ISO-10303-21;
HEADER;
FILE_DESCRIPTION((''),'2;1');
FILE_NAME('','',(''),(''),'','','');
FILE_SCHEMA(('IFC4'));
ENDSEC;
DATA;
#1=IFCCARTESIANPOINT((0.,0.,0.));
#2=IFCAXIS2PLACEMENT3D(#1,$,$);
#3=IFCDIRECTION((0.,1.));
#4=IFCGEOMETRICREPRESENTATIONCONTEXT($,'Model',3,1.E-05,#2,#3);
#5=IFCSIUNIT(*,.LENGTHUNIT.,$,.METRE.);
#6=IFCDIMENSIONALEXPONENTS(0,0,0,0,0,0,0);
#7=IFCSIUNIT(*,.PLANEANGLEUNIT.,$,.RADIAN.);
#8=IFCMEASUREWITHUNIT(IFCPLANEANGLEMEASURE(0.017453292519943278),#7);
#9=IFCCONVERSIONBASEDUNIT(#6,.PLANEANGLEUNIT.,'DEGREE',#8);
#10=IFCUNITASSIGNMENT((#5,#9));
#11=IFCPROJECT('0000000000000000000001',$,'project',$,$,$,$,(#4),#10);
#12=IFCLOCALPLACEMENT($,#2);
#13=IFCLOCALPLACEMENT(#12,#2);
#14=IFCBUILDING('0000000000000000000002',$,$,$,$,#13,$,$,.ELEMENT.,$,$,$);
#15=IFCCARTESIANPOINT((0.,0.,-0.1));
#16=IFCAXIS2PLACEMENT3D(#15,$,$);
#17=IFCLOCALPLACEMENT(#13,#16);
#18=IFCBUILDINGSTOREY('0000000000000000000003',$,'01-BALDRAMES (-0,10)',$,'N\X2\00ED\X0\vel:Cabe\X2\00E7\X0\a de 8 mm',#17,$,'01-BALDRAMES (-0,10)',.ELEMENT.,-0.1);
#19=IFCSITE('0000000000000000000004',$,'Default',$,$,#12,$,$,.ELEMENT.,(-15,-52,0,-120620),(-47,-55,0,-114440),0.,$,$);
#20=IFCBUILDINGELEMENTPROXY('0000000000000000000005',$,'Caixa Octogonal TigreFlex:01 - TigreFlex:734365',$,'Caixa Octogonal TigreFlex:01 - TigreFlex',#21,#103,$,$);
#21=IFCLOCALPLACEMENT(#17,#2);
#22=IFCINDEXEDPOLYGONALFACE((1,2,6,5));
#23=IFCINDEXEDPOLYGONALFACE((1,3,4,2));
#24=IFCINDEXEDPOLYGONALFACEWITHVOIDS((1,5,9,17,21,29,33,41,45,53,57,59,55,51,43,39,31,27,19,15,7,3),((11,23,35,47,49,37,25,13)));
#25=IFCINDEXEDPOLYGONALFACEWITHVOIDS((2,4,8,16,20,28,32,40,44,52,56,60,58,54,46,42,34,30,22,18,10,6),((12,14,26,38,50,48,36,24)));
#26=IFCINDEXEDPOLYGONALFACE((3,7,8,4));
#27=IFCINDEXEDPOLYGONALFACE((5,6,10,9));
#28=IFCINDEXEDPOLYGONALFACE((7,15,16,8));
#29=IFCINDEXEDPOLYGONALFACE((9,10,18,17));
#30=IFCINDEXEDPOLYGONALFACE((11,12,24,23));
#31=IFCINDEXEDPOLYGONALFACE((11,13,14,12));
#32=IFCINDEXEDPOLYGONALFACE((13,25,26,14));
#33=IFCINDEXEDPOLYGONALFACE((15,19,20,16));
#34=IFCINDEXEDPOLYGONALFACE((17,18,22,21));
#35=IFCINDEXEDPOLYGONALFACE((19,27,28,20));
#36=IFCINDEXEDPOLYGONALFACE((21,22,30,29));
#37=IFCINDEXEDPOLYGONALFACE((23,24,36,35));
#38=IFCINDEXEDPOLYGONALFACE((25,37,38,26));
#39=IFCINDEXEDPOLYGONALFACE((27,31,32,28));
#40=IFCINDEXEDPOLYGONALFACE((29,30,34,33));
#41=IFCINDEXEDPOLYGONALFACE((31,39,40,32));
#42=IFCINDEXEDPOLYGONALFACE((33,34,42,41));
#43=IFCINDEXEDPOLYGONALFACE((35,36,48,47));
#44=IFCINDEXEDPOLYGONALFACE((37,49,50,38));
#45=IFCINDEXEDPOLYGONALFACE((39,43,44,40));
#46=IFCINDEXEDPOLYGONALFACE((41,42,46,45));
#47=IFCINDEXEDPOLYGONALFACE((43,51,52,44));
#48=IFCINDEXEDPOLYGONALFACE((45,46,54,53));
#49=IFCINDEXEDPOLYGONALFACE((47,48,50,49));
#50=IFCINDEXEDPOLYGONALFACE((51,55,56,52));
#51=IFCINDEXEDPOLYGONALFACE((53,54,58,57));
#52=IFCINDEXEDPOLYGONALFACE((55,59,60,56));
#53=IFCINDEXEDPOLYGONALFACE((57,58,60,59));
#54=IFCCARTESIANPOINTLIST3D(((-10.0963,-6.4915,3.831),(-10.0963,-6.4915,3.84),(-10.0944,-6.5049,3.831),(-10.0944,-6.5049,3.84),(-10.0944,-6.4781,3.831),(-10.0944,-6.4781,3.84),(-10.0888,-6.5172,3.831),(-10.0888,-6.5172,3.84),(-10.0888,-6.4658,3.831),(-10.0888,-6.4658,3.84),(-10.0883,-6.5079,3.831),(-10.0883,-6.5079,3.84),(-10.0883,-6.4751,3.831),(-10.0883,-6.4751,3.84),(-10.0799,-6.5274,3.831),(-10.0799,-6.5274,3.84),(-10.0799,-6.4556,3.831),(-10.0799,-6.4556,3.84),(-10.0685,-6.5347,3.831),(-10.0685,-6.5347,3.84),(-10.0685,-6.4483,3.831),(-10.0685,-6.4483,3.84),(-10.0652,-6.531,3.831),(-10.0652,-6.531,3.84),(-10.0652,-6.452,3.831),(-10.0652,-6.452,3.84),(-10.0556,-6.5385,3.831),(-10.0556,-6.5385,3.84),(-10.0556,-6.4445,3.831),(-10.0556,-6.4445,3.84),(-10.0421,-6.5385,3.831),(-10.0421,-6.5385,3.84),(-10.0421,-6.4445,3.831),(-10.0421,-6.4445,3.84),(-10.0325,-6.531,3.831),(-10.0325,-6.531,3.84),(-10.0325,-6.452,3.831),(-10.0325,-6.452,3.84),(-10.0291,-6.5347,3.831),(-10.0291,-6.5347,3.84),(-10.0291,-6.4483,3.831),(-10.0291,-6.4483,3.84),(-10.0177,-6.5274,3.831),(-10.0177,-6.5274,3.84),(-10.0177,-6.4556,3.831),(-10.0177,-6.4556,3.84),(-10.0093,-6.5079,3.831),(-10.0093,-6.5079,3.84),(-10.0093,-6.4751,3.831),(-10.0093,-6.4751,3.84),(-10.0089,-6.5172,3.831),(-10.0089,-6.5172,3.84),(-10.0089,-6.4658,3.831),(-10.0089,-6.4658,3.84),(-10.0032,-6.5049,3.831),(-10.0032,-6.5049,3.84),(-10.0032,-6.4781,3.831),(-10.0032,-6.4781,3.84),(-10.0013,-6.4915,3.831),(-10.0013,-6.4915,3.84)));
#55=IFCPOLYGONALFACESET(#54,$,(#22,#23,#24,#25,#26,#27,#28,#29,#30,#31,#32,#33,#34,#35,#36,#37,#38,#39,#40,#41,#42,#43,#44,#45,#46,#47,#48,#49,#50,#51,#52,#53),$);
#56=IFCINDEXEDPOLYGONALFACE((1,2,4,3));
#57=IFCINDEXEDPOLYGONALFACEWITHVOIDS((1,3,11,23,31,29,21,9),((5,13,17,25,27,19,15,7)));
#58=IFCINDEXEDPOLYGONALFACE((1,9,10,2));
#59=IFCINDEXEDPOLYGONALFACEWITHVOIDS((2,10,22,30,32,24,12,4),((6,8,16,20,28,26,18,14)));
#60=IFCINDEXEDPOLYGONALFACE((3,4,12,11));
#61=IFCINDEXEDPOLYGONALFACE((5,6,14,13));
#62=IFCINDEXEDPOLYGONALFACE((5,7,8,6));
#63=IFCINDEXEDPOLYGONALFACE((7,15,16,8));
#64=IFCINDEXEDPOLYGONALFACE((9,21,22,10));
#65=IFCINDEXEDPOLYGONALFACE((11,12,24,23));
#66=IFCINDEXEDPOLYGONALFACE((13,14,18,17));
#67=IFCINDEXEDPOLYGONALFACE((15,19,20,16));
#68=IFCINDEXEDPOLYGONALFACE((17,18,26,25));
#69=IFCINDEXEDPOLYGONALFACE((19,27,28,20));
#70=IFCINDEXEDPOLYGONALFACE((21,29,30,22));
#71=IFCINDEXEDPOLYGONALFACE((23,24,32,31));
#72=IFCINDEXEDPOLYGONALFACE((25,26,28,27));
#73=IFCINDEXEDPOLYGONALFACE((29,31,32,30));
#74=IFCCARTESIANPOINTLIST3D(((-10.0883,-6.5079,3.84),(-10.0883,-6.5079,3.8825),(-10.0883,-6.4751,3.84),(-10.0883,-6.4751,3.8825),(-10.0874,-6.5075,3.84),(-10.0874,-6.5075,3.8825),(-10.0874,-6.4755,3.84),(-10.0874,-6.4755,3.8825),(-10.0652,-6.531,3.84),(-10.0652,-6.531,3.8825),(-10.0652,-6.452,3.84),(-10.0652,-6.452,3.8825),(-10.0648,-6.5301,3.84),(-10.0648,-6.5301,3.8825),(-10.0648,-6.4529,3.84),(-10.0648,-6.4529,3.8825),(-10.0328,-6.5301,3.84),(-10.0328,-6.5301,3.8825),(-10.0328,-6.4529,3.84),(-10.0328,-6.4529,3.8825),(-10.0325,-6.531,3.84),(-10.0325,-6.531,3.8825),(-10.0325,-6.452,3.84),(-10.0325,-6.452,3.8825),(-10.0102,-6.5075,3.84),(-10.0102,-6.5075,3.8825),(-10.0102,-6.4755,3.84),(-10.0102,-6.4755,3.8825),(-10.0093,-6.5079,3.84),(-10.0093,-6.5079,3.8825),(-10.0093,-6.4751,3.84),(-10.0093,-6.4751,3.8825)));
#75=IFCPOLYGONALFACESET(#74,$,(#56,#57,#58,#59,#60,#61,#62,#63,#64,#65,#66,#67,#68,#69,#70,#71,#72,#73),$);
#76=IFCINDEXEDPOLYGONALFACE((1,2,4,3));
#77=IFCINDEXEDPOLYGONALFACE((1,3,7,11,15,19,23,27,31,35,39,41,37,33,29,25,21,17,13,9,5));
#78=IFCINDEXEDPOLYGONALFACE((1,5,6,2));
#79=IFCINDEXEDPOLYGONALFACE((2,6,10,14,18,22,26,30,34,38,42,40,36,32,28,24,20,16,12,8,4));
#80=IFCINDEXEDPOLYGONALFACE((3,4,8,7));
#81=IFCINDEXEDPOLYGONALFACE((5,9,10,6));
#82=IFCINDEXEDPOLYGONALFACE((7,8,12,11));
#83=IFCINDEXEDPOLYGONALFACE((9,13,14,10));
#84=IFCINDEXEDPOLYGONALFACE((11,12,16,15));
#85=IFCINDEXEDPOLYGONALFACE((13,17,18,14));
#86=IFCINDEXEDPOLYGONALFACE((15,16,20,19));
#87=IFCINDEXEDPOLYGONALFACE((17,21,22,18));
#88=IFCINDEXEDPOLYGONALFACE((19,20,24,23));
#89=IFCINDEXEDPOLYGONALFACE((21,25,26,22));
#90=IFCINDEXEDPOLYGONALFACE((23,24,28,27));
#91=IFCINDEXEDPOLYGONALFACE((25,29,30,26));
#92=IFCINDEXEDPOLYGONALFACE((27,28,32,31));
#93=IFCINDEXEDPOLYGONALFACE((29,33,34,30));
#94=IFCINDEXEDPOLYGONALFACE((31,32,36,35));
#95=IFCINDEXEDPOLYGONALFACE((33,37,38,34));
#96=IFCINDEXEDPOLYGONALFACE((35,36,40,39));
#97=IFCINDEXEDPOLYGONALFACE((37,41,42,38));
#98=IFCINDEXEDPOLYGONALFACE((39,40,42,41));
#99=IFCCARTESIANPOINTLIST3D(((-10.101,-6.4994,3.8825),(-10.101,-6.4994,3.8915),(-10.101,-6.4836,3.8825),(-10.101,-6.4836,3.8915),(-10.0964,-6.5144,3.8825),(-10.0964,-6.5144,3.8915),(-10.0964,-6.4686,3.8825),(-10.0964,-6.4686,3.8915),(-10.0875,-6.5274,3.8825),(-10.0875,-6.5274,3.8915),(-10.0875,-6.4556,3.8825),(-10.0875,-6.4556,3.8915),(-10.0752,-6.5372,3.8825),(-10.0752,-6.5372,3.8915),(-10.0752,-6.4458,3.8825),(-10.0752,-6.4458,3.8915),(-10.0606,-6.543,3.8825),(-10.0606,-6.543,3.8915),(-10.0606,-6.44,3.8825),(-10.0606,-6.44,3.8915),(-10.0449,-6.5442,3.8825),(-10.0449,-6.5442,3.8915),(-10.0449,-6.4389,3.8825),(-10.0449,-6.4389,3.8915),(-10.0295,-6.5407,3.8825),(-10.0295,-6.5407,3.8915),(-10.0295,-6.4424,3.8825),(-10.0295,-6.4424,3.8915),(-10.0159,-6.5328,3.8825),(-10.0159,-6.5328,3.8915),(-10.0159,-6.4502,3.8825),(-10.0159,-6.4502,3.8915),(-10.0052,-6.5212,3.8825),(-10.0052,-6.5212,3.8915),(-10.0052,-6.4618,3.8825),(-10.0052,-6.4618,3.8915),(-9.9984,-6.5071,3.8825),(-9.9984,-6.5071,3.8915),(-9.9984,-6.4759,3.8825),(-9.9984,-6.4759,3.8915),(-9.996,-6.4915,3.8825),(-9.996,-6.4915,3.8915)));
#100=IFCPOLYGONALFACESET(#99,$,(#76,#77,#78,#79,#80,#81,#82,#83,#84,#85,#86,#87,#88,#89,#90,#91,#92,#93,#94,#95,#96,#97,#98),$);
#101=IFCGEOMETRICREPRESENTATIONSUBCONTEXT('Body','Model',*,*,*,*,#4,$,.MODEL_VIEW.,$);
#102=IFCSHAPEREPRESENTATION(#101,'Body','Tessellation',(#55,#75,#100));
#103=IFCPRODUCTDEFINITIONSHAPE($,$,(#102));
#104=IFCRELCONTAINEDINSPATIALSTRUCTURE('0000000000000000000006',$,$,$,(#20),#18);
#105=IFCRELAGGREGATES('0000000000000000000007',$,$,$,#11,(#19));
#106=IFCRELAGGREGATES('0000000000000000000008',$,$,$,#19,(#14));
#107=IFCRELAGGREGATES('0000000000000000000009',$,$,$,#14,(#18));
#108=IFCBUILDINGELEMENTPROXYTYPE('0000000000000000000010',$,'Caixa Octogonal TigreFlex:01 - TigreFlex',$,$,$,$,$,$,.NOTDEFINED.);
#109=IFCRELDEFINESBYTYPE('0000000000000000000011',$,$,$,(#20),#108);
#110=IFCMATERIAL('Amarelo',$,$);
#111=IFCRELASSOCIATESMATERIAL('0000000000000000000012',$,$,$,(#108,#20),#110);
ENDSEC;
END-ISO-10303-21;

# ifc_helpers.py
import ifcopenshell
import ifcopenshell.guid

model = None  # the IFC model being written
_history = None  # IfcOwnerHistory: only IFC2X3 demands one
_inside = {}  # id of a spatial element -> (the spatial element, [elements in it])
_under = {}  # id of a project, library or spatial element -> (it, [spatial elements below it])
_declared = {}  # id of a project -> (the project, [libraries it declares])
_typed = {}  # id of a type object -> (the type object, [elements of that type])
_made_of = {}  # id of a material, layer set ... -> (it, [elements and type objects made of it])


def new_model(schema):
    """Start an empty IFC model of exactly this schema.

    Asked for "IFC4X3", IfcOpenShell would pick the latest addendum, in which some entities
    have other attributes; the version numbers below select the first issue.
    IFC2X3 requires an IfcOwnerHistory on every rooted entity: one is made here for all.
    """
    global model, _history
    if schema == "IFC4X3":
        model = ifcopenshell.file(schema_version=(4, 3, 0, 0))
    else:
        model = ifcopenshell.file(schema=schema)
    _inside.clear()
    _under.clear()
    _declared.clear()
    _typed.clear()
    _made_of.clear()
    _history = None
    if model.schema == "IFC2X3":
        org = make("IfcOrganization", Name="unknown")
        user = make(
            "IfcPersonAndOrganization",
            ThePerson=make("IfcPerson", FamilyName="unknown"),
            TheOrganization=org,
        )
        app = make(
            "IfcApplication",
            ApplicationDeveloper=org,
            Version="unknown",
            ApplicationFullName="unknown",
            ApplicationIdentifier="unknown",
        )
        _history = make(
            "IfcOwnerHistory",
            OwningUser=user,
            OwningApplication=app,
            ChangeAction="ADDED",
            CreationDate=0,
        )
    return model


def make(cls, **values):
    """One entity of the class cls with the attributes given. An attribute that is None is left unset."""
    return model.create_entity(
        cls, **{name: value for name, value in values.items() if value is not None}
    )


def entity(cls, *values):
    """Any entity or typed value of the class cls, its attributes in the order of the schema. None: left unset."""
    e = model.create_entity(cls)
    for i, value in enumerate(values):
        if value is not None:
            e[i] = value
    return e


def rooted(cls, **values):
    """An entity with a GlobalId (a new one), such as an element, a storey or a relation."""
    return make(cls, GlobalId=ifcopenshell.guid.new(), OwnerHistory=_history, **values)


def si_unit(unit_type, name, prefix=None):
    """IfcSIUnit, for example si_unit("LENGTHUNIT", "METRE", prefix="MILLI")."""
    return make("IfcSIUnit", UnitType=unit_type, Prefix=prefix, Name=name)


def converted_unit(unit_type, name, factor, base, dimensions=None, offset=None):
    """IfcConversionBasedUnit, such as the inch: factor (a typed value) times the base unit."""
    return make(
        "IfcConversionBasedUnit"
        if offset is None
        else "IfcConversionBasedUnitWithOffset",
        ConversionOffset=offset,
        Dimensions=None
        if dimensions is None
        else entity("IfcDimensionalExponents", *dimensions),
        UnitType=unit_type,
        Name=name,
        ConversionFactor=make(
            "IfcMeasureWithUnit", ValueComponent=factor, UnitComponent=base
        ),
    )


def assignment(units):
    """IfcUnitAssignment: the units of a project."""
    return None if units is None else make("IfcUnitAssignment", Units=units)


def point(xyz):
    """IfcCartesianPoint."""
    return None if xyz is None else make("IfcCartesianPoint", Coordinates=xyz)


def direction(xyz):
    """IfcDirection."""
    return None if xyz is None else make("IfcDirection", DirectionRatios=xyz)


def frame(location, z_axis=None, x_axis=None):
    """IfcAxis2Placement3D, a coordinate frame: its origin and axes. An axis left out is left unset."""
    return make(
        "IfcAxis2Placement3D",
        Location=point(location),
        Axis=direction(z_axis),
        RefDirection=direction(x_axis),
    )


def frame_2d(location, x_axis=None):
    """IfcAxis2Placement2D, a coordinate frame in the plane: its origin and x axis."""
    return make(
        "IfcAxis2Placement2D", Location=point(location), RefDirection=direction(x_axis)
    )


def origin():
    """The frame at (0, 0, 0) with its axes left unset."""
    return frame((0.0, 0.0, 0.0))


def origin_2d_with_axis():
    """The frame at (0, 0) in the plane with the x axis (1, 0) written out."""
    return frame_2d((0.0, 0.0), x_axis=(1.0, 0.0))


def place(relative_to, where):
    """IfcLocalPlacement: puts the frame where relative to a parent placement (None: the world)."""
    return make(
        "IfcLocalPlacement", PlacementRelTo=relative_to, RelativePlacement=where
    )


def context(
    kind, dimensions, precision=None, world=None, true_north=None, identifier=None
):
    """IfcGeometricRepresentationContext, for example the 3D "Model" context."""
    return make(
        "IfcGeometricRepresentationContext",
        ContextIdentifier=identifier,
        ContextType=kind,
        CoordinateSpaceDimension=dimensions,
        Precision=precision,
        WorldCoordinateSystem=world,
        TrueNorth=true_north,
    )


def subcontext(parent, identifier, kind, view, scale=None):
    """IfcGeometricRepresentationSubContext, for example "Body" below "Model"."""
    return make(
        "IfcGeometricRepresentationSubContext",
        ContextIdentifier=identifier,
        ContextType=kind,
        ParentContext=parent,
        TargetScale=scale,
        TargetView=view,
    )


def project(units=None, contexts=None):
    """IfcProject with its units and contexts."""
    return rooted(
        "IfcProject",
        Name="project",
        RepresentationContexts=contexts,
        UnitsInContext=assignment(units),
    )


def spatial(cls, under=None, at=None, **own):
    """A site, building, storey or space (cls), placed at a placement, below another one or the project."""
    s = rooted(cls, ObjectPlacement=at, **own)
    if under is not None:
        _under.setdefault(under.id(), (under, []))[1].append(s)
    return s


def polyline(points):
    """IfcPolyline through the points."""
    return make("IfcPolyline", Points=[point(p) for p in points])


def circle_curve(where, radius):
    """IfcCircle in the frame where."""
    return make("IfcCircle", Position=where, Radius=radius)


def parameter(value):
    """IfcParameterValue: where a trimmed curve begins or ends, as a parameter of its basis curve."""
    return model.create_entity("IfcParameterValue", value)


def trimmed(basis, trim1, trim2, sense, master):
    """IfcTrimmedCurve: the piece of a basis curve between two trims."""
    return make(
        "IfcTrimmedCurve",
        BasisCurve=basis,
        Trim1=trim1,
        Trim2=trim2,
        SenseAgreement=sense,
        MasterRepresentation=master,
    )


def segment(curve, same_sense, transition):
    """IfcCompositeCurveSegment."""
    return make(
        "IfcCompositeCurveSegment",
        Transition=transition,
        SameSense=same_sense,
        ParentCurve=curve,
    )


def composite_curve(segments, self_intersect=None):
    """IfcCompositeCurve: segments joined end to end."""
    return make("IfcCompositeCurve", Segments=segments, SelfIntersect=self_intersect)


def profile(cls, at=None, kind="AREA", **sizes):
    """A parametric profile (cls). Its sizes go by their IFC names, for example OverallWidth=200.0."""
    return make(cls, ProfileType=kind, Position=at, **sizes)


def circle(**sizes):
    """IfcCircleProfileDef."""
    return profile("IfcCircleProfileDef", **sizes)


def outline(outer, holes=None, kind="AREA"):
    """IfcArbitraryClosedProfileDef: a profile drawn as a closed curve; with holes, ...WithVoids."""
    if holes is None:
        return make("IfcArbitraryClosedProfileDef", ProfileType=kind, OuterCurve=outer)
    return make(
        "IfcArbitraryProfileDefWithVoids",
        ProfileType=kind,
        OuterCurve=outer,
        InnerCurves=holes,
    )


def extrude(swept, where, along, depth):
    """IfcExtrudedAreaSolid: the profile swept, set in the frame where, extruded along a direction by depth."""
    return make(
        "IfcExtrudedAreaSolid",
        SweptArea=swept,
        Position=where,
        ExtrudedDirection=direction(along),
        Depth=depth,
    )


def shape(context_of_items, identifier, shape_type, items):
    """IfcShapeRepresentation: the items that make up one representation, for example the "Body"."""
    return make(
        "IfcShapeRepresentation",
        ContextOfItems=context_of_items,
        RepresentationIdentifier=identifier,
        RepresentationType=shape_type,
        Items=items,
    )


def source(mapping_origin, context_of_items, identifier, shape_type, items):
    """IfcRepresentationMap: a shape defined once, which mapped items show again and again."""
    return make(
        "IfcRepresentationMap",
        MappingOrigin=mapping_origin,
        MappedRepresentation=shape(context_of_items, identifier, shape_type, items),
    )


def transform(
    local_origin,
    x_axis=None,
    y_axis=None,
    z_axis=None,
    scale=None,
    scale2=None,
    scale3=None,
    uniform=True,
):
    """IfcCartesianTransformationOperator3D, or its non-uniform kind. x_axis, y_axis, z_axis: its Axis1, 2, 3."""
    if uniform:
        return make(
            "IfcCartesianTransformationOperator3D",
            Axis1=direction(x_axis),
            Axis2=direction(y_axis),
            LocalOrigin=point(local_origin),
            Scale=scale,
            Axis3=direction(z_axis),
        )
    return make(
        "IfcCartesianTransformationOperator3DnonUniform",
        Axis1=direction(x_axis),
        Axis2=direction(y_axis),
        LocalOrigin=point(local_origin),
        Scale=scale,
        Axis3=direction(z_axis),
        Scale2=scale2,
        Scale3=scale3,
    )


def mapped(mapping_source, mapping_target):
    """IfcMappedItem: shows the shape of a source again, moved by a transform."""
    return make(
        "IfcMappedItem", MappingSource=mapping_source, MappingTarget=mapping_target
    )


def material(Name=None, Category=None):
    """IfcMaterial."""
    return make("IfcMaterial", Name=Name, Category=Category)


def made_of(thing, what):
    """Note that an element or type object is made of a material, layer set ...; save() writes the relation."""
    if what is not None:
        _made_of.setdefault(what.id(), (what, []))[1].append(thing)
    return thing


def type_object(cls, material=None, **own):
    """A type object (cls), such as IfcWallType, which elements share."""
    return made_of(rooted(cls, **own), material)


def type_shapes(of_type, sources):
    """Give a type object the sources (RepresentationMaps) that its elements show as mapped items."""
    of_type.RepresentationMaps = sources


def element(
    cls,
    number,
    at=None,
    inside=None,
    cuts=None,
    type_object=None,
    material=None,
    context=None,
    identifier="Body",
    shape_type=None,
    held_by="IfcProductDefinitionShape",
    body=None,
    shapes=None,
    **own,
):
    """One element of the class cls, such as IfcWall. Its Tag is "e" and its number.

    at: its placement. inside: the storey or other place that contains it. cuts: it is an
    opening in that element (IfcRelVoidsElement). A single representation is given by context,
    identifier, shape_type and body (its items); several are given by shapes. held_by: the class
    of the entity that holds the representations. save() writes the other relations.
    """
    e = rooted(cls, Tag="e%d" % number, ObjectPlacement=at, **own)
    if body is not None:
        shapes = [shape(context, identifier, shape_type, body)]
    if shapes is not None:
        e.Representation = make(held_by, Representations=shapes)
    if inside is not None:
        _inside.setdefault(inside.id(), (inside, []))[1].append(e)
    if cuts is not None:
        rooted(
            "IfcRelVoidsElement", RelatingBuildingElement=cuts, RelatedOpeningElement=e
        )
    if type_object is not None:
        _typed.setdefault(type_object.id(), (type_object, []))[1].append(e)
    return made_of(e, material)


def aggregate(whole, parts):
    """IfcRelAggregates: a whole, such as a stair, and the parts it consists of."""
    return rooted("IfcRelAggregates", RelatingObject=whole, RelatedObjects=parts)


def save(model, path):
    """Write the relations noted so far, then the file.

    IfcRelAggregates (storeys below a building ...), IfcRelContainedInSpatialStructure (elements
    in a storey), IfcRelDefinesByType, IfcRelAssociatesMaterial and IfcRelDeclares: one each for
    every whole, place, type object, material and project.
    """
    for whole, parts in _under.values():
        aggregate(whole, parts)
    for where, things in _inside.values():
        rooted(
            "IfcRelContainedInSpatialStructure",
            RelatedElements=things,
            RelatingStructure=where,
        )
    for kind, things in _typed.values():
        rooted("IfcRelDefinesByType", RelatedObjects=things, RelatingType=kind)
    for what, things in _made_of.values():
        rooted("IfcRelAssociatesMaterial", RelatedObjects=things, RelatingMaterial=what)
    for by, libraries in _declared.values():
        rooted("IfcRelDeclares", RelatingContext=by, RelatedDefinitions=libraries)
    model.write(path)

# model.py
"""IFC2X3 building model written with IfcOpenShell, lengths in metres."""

from ifc_helpers import new_model, entity, si_unit, converted_unit, direction, frame, frame_2d, origin, origin_2d_with_axis, place, context, subcontext, project, spatial, polyline, circle_curve, parameter, trimmed, segment, composite_curve, circle, outline, extrude, source, transform, mapped, material, type_object, type_shapes, element, save


model = new_model("IFC2X3")

# Units and contexts
model_context = context("Model", 3, precision=1e-05, world=origin(), true_north=direction((0.0, 1.0)))
body_context = subcontext(model_context, "Body", "Model", "MODEL_VIEW")
ifc_project = project(units=[si_unit("LENGTHUNIT", "METRE"), converted_unit("PLANEANGLEUNIT", "DEGREE", entity("IfcPlaneAngleMeasure", 0.017453292519943278), si_unit("PLANEANGLEUNIT", "RADIAN"), dimensions=[0, 0, 0, 0, 0, 0, 0])], contexts=[model_context])

# Site, building, storey
site_placement = place(None, origin())
site = spatial("IfcSite", under=ifc_project, at=site_placement, Name="Default", CompositionType="ELEMENT", RefLatitude=(-15, -52, 0, -120620), RefLongitude=(-47, -55, 0, -114440), RefElevation=0.0)
building_placement = place(site_placement, origin())
building = spatial("IfcBuilding", under=site, at=building_placement, CompositionType="ELEMENT")
storey_placement = place(building_placement, frame((0.0, 0.0, -0.1)))
storey = spatial("IfcBuildingStorey", under=building, at=storey_placement, Name="01-BALDRAMES (-0,10)", ObjectType="Nível:Cabeça de 8 mm", LongName="01-BALDRAMES (-0,10)", CompositionType="ELEMENT", Elevation=-0.1)

# Building element proxy
ifc_material_1 = material(Name="Amarelo")
building_element_proxy_type_1 = type_object("IfcBuildingElementProxyType", Name="Caixa Octogonal TigreFlex:01 - TigreFlex", PredefinedType="NOTDEFINED", material=ifc_material_1)
shared_shape_1 = source(origin(), body_context, "Body", "SweptSolid", [
    extrude(outline(composite_curve([segment(trimmed(circle_curve(origin_2d_with_axis(), 0.0475), [parameter(180.0)], [parameter(360.0)], True, "PARAMETER"), True, "CONTINUOUS"), segment(trimmed(circle_curve(origin_2d_with_axis(), 0.0475), [parameter(0.0)], [parameter(180.0)], True, "PARAMETER"), True, "CONTINUOUS")], self_intersect=False), holes=[polyline([(-0.0395, 0.0164), (-0.0164, 0.0395), (0.0164, 0.0395), (0.0395, 0.0164), (0.0395, -0.0164), (0.0164, -0.0395), (-0.0164, -0.0395), (-0.0395, -0.0164), (-0.0395, 0.0164)])]), frame((0.0, 0.0, 2.7698)), (0.0, 0.0, 1.0), 0.009),
    extrude(outline(polyline([(-0.0164, -0.0395), (0.0164, -0.0395), (0.0395, -0.0164), (0.0395, 0.0164), (0.0164, 0.0395), (-0.0164, 0.0395), (-0.0395, 0.0164), (-0.0395, -0.0164), (-0.0164, -0.0395)]), holes=[polyline([(-0.016, -0.0386), (-0.0386, -0.016), (-0.0386, 0.016), (-0.016, 0.0386), (0.016, 0.0386), (0.0386, 0.016), (0.0386, -0.016), (0.016, -0.0386), (-0.016, -0.0386)])]), frame((0.0, 0.0, 2.7788), z_axis=(0.0, 0.0, 1.0), x_axis=(0.0, -1.0, 0.0)), (0.0, 0.0, 1.0), 0.0425),
    extrude(circle(Radius=0.0528, at=frame_2d((0.0, 0.0), x_axis=(1.0, 0.0))), frame((0.0, 0.0, 2.8213)), (0.0, 0.0, 1.0), 0.009),
])
type_shapes(building_element_proxy_type_1, [shared_shape_1])
proxy_1_placement = place(storey_placement, frame((-10.0488, -6.4915, 1.0613)))
element("IfcBuildingElementProxy", 1, at=proxy_1_placement, inside=storey, type_object=building_element_proxy_type_1, material=ifc_material_1, Name="Caixa Octogonal TigreFlex:01 - TigreFlex:734365", ObjectType="Caixa Octogonal TigreFlex:01 - TigreFlex", context=body_context, shape_type="MappedRepresentation", body=[
    mapped(shared_shape_1, transform((0.0, 0.0, 0.0), scale=1.0)),
])

save(model, "model.ifc")
